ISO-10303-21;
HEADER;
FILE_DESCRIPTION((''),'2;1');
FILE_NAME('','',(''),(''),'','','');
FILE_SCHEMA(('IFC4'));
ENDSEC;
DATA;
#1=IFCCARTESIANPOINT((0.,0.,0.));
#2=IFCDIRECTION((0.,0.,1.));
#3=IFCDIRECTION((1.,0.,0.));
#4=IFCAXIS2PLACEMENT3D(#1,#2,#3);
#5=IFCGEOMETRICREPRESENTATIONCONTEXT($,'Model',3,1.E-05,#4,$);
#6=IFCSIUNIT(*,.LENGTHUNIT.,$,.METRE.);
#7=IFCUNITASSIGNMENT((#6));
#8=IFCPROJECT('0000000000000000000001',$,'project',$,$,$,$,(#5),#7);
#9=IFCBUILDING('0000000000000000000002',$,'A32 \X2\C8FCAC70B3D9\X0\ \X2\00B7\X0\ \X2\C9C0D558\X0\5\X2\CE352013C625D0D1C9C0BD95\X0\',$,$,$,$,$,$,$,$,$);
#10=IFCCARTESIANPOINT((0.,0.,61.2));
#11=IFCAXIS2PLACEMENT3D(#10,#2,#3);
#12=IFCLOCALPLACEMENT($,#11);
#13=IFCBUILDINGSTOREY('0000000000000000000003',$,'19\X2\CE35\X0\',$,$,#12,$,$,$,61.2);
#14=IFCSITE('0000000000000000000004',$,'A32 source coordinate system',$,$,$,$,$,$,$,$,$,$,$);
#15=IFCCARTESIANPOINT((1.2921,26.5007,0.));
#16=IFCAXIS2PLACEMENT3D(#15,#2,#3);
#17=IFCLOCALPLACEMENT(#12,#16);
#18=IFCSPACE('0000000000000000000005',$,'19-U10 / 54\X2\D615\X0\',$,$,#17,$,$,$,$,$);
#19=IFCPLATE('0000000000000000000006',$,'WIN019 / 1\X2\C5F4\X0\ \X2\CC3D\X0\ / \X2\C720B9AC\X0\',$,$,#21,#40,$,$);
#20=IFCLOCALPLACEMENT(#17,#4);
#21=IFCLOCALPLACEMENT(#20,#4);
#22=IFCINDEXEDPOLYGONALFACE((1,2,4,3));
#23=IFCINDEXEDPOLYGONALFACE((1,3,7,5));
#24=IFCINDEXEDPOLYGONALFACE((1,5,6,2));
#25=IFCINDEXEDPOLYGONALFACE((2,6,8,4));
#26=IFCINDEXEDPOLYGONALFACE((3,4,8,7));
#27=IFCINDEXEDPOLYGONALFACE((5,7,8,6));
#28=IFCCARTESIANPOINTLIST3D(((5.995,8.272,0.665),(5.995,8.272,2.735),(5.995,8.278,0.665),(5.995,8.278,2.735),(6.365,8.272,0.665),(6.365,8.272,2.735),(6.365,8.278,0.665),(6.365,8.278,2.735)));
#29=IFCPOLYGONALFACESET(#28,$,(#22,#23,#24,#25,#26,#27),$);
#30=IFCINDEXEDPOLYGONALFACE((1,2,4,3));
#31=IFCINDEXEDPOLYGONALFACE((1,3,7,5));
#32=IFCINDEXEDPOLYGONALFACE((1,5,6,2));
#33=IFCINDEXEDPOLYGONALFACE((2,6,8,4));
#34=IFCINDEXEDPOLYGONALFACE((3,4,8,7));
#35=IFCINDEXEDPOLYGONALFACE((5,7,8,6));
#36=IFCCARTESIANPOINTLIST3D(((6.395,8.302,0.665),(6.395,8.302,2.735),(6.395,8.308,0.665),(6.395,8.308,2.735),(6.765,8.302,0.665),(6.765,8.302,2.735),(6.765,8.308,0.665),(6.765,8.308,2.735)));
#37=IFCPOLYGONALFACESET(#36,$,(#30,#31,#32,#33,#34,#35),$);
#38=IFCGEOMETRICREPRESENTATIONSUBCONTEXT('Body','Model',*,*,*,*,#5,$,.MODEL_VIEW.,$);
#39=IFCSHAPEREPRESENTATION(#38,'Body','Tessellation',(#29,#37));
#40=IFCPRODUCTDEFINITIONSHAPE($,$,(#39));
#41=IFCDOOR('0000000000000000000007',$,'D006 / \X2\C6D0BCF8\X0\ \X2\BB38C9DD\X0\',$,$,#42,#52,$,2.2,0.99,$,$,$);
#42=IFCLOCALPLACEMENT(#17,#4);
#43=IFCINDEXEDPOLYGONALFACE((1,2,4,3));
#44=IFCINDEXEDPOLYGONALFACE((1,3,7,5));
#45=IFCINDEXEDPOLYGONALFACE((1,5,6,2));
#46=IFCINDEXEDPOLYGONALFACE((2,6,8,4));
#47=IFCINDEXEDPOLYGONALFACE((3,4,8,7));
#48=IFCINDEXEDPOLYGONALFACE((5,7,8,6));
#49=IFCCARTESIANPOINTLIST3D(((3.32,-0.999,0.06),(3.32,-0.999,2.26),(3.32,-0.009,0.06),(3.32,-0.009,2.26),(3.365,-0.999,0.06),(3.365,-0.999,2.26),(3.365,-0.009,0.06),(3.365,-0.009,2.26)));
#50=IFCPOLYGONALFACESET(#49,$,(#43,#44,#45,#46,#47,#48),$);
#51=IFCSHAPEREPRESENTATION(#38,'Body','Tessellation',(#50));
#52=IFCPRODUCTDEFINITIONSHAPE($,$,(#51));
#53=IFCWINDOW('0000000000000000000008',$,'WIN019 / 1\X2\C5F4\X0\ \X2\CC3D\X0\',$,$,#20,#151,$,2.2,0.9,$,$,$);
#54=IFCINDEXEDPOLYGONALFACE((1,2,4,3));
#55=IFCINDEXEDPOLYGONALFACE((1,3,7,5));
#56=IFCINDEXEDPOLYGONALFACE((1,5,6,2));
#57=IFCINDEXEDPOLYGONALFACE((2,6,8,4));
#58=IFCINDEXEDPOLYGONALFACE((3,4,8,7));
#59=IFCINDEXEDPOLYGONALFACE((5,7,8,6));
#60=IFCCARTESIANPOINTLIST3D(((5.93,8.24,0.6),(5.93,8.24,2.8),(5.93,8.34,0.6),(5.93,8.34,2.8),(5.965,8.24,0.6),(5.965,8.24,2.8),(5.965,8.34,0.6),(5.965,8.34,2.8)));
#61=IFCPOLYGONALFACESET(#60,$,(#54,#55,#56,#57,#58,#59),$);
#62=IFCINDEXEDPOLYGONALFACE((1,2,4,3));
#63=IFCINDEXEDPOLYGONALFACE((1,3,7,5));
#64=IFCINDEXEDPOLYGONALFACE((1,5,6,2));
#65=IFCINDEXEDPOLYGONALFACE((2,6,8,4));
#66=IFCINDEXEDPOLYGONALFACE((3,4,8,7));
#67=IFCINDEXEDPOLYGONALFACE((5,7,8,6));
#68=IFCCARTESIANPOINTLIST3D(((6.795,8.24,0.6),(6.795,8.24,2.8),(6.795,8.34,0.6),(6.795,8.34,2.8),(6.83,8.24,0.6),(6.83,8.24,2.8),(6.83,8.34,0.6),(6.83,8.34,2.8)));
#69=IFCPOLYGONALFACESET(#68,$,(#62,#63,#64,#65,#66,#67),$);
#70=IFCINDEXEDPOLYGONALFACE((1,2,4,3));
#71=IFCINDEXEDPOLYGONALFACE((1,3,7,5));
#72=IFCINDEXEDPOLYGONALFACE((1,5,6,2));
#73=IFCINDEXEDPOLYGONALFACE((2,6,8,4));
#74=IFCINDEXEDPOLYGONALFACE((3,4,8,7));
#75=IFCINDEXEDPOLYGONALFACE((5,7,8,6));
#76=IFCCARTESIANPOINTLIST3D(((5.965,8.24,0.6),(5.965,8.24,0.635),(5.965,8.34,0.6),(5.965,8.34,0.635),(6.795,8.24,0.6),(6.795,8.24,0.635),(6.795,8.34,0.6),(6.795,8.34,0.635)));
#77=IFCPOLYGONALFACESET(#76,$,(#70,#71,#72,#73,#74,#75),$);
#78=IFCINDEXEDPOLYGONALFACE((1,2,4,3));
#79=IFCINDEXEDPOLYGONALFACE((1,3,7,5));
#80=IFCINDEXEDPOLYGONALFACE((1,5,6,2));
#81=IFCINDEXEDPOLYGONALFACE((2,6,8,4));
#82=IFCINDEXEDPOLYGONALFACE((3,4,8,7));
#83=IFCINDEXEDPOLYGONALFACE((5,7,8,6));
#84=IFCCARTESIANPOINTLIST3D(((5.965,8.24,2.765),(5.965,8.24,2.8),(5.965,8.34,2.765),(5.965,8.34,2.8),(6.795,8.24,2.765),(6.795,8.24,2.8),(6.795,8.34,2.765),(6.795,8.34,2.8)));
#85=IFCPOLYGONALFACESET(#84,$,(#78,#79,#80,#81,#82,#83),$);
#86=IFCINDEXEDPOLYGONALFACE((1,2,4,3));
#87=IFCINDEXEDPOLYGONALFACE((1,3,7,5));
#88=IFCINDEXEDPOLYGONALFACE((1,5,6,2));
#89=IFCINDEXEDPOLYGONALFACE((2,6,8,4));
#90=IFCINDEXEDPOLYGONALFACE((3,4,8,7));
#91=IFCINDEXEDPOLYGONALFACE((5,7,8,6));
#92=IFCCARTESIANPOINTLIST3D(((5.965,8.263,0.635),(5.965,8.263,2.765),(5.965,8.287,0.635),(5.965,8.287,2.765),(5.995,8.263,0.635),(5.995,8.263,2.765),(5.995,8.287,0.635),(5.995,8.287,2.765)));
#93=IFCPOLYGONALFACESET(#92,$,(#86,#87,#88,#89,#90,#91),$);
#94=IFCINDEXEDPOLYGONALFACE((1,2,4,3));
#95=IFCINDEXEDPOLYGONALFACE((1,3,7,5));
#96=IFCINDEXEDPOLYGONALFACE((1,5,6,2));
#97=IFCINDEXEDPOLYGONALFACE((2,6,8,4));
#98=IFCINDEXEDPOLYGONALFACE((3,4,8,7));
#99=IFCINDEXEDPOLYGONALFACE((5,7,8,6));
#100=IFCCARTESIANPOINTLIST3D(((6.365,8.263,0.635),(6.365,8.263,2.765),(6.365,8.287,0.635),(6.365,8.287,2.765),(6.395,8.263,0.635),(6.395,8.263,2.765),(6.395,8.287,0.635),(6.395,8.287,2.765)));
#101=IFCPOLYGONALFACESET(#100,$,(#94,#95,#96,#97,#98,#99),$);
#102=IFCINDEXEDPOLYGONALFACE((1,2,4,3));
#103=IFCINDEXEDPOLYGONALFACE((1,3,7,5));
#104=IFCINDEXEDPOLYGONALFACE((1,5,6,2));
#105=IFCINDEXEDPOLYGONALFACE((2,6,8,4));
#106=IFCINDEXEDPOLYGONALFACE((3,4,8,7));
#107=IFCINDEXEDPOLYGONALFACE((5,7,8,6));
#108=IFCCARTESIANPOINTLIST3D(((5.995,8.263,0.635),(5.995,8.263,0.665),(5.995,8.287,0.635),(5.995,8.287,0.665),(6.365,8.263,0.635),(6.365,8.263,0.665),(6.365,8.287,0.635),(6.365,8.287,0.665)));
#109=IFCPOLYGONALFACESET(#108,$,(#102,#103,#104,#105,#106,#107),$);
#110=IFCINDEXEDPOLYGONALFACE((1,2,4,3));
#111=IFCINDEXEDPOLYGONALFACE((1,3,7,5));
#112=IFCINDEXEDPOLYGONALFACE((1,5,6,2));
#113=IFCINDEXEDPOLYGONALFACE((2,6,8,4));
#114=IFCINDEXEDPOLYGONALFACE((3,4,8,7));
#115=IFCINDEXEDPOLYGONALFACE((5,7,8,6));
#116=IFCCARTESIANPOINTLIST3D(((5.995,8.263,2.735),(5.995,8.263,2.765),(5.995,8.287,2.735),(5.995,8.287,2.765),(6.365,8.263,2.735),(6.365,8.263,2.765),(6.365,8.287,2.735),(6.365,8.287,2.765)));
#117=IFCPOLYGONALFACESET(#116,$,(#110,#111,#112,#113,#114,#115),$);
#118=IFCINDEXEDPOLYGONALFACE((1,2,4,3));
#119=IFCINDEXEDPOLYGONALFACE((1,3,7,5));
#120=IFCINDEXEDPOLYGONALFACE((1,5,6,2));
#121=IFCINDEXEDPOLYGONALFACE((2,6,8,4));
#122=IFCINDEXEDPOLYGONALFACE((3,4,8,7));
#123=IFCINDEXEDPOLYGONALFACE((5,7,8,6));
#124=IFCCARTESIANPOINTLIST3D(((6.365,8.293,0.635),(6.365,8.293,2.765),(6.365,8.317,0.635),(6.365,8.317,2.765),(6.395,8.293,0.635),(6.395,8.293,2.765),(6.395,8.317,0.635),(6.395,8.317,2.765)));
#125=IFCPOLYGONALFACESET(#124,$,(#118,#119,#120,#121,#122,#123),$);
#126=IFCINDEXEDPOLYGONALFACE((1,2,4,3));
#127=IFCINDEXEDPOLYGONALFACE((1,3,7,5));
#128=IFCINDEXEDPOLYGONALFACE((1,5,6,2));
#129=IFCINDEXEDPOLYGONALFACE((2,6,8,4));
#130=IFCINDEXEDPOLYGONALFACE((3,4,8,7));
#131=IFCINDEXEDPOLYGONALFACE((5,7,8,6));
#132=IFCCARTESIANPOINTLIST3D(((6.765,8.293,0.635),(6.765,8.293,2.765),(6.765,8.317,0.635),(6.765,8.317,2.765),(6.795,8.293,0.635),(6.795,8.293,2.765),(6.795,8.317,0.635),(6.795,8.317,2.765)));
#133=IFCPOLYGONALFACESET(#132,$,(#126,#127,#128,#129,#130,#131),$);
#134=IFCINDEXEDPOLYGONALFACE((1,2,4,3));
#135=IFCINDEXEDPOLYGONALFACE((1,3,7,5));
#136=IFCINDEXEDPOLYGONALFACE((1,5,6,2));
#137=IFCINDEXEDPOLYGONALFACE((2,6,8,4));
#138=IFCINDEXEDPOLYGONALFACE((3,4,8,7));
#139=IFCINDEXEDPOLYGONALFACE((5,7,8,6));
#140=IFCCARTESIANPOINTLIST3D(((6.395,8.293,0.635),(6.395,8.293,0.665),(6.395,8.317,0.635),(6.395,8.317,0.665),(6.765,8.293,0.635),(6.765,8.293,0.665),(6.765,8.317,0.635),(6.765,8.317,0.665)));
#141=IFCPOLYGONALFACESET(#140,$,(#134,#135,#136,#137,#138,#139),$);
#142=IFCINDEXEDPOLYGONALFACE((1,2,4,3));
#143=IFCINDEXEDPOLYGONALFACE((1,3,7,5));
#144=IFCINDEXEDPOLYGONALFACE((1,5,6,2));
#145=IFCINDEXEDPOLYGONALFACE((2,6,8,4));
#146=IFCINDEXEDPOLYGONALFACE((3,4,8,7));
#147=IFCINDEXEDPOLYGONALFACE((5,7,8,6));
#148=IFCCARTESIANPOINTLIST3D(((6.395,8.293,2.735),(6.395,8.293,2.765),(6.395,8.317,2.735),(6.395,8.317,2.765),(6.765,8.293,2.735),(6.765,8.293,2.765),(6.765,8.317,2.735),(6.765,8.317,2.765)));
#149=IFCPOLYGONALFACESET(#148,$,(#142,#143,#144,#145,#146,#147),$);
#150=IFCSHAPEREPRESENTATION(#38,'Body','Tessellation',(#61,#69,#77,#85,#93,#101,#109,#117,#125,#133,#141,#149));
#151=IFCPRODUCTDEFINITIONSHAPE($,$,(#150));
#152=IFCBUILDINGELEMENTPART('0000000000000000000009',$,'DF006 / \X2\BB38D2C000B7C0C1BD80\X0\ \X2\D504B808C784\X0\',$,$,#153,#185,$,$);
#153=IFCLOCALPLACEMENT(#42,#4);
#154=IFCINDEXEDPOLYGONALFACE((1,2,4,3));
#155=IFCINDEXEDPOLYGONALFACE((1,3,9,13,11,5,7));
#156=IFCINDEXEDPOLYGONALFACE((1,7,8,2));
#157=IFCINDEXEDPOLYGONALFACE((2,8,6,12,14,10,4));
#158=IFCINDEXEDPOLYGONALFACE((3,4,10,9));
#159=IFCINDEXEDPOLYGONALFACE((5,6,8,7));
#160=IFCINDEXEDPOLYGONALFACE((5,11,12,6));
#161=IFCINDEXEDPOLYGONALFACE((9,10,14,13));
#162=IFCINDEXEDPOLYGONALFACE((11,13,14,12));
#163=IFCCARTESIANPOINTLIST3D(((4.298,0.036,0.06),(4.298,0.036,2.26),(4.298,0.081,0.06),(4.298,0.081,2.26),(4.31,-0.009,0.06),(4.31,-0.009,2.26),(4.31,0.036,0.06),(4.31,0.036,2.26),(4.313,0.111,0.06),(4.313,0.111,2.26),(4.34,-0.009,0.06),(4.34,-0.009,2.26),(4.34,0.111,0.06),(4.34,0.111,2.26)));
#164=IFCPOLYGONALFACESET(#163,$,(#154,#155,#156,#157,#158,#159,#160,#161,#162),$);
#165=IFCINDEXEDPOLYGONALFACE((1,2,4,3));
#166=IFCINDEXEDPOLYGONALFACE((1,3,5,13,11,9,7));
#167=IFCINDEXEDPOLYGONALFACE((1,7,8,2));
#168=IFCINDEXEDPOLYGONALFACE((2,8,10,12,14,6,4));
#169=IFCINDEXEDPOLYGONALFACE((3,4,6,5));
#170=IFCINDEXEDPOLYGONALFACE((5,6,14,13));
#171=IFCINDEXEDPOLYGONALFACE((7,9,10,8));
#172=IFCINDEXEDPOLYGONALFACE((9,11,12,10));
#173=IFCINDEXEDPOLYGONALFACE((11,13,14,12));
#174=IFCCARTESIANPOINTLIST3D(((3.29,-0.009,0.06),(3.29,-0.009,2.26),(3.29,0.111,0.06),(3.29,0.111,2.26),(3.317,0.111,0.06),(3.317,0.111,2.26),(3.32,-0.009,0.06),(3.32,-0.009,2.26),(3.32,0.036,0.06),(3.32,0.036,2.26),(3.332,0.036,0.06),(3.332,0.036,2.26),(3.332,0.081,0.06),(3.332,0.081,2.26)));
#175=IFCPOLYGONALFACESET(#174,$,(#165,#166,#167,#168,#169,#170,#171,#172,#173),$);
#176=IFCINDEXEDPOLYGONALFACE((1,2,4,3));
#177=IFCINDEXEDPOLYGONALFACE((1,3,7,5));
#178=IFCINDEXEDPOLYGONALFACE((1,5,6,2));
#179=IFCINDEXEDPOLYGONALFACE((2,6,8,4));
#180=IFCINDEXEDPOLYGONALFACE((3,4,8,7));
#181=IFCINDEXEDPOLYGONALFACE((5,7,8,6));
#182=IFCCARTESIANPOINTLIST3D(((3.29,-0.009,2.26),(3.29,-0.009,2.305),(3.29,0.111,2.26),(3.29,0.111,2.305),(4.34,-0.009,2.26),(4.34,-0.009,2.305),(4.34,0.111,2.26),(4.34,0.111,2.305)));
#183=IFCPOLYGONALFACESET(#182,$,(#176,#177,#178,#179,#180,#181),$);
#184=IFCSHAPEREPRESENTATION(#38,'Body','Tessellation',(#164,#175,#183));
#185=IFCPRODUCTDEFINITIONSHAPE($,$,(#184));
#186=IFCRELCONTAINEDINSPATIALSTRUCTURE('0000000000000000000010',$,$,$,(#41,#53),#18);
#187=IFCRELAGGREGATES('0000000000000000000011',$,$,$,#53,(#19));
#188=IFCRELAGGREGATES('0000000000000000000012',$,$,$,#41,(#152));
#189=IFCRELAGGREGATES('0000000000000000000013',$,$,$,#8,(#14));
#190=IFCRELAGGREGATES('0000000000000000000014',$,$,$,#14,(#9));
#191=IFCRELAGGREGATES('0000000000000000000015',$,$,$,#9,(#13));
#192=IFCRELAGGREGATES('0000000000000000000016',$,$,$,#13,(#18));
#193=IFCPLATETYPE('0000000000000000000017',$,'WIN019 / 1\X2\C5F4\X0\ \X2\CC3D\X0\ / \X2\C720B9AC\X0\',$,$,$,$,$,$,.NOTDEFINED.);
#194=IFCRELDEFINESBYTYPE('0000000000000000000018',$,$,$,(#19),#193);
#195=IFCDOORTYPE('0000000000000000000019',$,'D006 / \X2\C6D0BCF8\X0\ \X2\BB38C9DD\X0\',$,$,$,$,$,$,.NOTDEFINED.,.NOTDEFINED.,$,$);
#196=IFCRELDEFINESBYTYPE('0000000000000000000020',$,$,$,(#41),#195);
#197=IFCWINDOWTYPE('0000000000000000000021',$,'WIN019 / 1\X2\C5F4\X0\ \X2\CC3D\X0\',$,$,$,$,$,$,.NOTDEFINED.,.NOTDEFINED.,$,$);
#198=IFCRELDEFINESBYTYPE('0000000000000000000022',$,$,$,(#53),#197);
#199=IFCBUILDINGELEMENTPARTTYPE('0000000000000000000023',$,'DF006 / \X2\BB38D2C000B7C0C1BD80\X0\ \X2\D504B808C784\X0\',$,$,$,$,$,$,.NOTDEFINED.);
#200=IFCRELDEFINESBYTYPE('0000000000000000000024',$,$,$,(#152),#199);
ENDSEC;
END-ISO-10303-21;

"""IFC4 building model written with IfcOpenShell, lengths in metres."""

from ifc_helpers import new_model, si_unit, frame, origin, origin_with_axes, place, context, subcontext, project, spatial, polyline, outline, extrude, source, transform, mapped, type_object, type_shapes, element, aggregate, save


model = new_model("IFC4")

# Units and contexts
model_context = context("Model", 3, precision=1e-05, world=origin_with_axes())
body_context = subcontext(model_context, "Body", "Model", "MODEL_VIEW")
ifc_project = project(units=[si_unit("LENGTHUNIT", "METRE")], contexts=[model_context])

# Plate
storey_placement = place(None, frame((0.0, 0.0, 61.2), z_axis=(0.0, 0.0, 1.0), x_axis=(1.0, 0.0, 0.0)))
space_placement = place(storey_placement, frame((1.2921, 26.5007, 0.0), z_axis=(0.0, 0.0, 1.0), x_axis=(1.0, 0.0, 0.0)))
plate_type_1 = type_object("IfcPlateType", Name="WIN019 / 1열 창 / 유리", PredefinedType="NOTDEFINED")
shared_shape_1 = source(origin(), body_context, "Body", "SweptSolid", [
    extrude(outline(polyline([(5.995, 8.272), (5.995, 8.278), (6.365, 8.278), (6.365, 8.272), (5.995, 8.272)])), frame((0.0, 0.0, 0.665)), (0.0, 0.0, 1.0), 2.07),
    extrude(outline(polyline([(6.395, 8.302), (6.395, 8.308), (6.765, 8.308), (6.765, 8.302), (6.395, 8.302)])), frame((0.0, 0.0, 0.665)), (0.0, 0.0, 1.0), 2.07),
])
type_shapes(plate_type_1, [shared_shape_1])
window_1_placement = place(space_placement, origin_with_axes())
plate_1_placement = place(window_1_placement, origin_with_axes())
plate_1 = element("IfcPlate", 1, at=plate_1_placement, type_object=plate_type_1, Name="WIN019 / 1열 창 / 유리", context=body_context, shape_type="MappedRepresentation", body=[
    mapped(shared_shape_1, transform((0.0, 0.0, 0.0), scale=1.0)),
])

# Site, building, storey, space
site = spatial("IfcSite", under=ifc_project, Name="A32 source coordinate system")
building = spatial("IfcBuilding", under=site, Name="A32 주거동 · 지하5층–옥탑지붕")
storey = spatial("IfcBuildingStorey", under=building, at=storey_placement, Name="19층", Elevation=61.2)
space = spatial("IfcSpace", under=storey, at=space_placement, Name="19-U10 / 54형")

# Door
door_type_1 = type_object("IfcDoorType", Name="D006 / 원본 문짝", OperationType="NOTDEFINED", PredefinedType="NOTDEFINED")
shared_shape_2 = source(origin(), body_context, "Body", "SweptSolid", [
    extrude(outline(polyline([(3.365, -0.999), (3.32, -0.999), (3.32, -0.009), (3.365, -0.009), (3.365, -0.999)])), frame((0.0, 0.0, 0.06)), (0.0, 0.0, 1.0), 2.2),
])
type_shapes(door_type_1, [shared_shape_2])
door_1_placement = place(space_placement, origin_with_axes())
door_1 = element("IfcDoor", 2, at=door_1_placement, inside=space, type_object=door_type_1, Name="D006 / 원본 문짝", OverallHeight=2.2, OverallWidth=0.99, context=body_context, shape_type="MappedRepresentation", body=[
    mapped(shared_shape_2, transform((0.0, 0.0, 0.0), scale=1.0)),
])

# Window
window_type_1 = type_object("IfcWindowType", Name="WIN019 / 1열 창", PartitioningType="NOTDEFINED", PredefinedType="NOTDEFINED")
shared_shape_3 = source(origin(), body_context, "Body", "SweptSolid", [
    extrude(outline(polyline([(5.93, 8.24), (5.93, 8.34), (5.965, 8.34), (5.965, 8.24), (5.93, 8.24)])), frame((0.0, 0.0, 0.6)), (0.0, 0.0, 1.0), 2.2),
    extrude(outline(polyline([(6.795, 8.24), (6.795, 8.34), (6.83, 8.34), (6.83, 8.24), (6.795, 8.24)])), frame((0.0, 0.0, 0.6)), (0.0, 0.0, 1.0), 2.2),
    extrude(outline(polyline([(5.965, 8.24), (5.965, 8.34), (6.795, 8.34), (6.795, 8.24), (5.965, 8.24)])), frame((0.0, 0.0, 0.6)), (0.0, 0.0, 1.0), 0.035),
    extrude(outline(polyline([(5.965, 8.24), (5.965, 8.34), (6.795, 8.34), (6.795, 8.24), (5.965, 8.24)])), frame((0.0, 0.0, 2.765)), (0.0, 0.0, 1.0), 0.035),
    extrude(outline(polyline([(5.965, 8.263), (5.965, 8.287), (5.995, 8.287), (5.995, 8.263), (5.965, 8.263)])), frame((0.0, 0.0, 0.635)), (0.0, 0.0, 1.0), 2.13),
    extrude(outline(polyline([(6.365, 8.263), (6.365, 8.287), (6.395, 8.287), (6.395, 8.263), (6.365, 8.263)])), frame((0.0, 0.0, 0.635)), (0.0, 0.0, 1.0), 2.13),
    extrude(outline(polyline([(5.995, 8.263), (5.995, 8.287), (6.365, 8.287), (6.365, 8.263), (5.995, 8.263)])), frame((0.0, 0.0, 0.635)), (0.0, 0.0, 1.0), 0.03),
    extrude(outline(polyline([(5.995, 8.263), (5.995, 8.287), (6.365, 8.287), (6.365, 8.263), (5.995, 8.263)])), frame((0.0, 0.0, 2.735)), (0.0, 0.0, 1.0), 0.03),
    extrude(outline(polyline([(6.365, 8.293), (6.365, 8.317), (6.395, 8.317), (6.395, 8.293), (6.365, 8.293)])), frame((0.0, 0.0, 0.635)), (0.0, 0.0, 1.0), 2.13),
    extrude(outline(polyline([(6.765, 8.293), (6.765, 8.317), (6.795, 8.317), (6.795, 8.293), (6.765, 8.293)])), frame((0.0, 0.0, 0.635)), (0.0, 0.0, 1.0), 2.13),
    extrude(outline(polyline([(6.395, 8.293), (6.395, 8.317), (6.765, 8.317), (6.765, 8.293), (6.395, 8.293)])), frame((0.0, 0.0, 0.635)), (0.0, 0.0, 1.0), 0.03),
    extrude(outline(polyline([(6.395, 8.293), (6.395, 8.317), (6.765, 8.317), (6.765, 8.293), (6.395, 8.293)])), frame((0.0, 0.0, 2.735)), (0.0, 0.0, 1.0), 0.03),
])
type_shapes(window_type_1, [shared_shape_3])
window_1 = element("IfcWindow", 3, at=window_1_placement, inside=space, type_object=window_type_1, Name="WIN019 / 1열 창", OverallHeight=2.2, OverallWidth=0.9, context=body_context, shape_type="MappedRepresentation", body=[
    mapped(shared_shape_3, transform((0.0, 0.0, 0.0), scale=1.0)),
])
aggregate(window_1, [plate_1])

# Building element part
building_element_part_type_1 = type_object("IfcBuildingElementPartType", Name="DF006 / 문틀·상부 프레임", PredefinedType="NOTDEFINED")
shared_shape_4 = source(origin(), body_context, "Body", "SweptSolid", [
    extrude(outline(polyline([(4.31, -0.009), (4.31, 0.036), (4.298, 0.036), (4.298, 0.081), (4.313, 0.111), (4.34, 0.111), (4.34, -0.009), (4.31, -0.009)])), frame((0.0, 0.0, 0.06)), (0.0, 0.0, 1.0), 2.2),
    extrude(outline(polyline([(3.29, 0.111), (3.317, 0.111), (3.332, 0.081), (3.332, 0.036), (3.32, 0.036), (3.32, -0.009), (3.29, -0.009), (3.29, 0.111)])), frame((0.0, 0.0, 0.06)), (0.0, 0.0, 1.0), 2.2),
    extrude(outline(polyline([(3.29, -0.009), (3.29, 0.111), (4.34, 0.111), (4.34, -0.009), (3.29, -0.009)])), frame((0.0, 0.0, 2.26)), (0.0, 0.0, 1.0), 0.045),
])
type_shapes(building_element_part_type_1, [shared_shape_4])
building_element_part_1_placement = place(door_1_placement, origin_with_axes())
building_element_part_1 = element("IfcBuildingElementPart", 4, at=building_element_part_1_placement, type_object=building_element_part_type_1, Name="DF006 / 문틀·상부 프레임", context=body_context, shape_type="MappedRepresentation", body=[
    mapped(shared_shape_4, transform((0.0, 0.0, 0.0), scale=1.0)),
])
aggregate(door_1, [building_element_part_1])

save(model, "model.ifc")
